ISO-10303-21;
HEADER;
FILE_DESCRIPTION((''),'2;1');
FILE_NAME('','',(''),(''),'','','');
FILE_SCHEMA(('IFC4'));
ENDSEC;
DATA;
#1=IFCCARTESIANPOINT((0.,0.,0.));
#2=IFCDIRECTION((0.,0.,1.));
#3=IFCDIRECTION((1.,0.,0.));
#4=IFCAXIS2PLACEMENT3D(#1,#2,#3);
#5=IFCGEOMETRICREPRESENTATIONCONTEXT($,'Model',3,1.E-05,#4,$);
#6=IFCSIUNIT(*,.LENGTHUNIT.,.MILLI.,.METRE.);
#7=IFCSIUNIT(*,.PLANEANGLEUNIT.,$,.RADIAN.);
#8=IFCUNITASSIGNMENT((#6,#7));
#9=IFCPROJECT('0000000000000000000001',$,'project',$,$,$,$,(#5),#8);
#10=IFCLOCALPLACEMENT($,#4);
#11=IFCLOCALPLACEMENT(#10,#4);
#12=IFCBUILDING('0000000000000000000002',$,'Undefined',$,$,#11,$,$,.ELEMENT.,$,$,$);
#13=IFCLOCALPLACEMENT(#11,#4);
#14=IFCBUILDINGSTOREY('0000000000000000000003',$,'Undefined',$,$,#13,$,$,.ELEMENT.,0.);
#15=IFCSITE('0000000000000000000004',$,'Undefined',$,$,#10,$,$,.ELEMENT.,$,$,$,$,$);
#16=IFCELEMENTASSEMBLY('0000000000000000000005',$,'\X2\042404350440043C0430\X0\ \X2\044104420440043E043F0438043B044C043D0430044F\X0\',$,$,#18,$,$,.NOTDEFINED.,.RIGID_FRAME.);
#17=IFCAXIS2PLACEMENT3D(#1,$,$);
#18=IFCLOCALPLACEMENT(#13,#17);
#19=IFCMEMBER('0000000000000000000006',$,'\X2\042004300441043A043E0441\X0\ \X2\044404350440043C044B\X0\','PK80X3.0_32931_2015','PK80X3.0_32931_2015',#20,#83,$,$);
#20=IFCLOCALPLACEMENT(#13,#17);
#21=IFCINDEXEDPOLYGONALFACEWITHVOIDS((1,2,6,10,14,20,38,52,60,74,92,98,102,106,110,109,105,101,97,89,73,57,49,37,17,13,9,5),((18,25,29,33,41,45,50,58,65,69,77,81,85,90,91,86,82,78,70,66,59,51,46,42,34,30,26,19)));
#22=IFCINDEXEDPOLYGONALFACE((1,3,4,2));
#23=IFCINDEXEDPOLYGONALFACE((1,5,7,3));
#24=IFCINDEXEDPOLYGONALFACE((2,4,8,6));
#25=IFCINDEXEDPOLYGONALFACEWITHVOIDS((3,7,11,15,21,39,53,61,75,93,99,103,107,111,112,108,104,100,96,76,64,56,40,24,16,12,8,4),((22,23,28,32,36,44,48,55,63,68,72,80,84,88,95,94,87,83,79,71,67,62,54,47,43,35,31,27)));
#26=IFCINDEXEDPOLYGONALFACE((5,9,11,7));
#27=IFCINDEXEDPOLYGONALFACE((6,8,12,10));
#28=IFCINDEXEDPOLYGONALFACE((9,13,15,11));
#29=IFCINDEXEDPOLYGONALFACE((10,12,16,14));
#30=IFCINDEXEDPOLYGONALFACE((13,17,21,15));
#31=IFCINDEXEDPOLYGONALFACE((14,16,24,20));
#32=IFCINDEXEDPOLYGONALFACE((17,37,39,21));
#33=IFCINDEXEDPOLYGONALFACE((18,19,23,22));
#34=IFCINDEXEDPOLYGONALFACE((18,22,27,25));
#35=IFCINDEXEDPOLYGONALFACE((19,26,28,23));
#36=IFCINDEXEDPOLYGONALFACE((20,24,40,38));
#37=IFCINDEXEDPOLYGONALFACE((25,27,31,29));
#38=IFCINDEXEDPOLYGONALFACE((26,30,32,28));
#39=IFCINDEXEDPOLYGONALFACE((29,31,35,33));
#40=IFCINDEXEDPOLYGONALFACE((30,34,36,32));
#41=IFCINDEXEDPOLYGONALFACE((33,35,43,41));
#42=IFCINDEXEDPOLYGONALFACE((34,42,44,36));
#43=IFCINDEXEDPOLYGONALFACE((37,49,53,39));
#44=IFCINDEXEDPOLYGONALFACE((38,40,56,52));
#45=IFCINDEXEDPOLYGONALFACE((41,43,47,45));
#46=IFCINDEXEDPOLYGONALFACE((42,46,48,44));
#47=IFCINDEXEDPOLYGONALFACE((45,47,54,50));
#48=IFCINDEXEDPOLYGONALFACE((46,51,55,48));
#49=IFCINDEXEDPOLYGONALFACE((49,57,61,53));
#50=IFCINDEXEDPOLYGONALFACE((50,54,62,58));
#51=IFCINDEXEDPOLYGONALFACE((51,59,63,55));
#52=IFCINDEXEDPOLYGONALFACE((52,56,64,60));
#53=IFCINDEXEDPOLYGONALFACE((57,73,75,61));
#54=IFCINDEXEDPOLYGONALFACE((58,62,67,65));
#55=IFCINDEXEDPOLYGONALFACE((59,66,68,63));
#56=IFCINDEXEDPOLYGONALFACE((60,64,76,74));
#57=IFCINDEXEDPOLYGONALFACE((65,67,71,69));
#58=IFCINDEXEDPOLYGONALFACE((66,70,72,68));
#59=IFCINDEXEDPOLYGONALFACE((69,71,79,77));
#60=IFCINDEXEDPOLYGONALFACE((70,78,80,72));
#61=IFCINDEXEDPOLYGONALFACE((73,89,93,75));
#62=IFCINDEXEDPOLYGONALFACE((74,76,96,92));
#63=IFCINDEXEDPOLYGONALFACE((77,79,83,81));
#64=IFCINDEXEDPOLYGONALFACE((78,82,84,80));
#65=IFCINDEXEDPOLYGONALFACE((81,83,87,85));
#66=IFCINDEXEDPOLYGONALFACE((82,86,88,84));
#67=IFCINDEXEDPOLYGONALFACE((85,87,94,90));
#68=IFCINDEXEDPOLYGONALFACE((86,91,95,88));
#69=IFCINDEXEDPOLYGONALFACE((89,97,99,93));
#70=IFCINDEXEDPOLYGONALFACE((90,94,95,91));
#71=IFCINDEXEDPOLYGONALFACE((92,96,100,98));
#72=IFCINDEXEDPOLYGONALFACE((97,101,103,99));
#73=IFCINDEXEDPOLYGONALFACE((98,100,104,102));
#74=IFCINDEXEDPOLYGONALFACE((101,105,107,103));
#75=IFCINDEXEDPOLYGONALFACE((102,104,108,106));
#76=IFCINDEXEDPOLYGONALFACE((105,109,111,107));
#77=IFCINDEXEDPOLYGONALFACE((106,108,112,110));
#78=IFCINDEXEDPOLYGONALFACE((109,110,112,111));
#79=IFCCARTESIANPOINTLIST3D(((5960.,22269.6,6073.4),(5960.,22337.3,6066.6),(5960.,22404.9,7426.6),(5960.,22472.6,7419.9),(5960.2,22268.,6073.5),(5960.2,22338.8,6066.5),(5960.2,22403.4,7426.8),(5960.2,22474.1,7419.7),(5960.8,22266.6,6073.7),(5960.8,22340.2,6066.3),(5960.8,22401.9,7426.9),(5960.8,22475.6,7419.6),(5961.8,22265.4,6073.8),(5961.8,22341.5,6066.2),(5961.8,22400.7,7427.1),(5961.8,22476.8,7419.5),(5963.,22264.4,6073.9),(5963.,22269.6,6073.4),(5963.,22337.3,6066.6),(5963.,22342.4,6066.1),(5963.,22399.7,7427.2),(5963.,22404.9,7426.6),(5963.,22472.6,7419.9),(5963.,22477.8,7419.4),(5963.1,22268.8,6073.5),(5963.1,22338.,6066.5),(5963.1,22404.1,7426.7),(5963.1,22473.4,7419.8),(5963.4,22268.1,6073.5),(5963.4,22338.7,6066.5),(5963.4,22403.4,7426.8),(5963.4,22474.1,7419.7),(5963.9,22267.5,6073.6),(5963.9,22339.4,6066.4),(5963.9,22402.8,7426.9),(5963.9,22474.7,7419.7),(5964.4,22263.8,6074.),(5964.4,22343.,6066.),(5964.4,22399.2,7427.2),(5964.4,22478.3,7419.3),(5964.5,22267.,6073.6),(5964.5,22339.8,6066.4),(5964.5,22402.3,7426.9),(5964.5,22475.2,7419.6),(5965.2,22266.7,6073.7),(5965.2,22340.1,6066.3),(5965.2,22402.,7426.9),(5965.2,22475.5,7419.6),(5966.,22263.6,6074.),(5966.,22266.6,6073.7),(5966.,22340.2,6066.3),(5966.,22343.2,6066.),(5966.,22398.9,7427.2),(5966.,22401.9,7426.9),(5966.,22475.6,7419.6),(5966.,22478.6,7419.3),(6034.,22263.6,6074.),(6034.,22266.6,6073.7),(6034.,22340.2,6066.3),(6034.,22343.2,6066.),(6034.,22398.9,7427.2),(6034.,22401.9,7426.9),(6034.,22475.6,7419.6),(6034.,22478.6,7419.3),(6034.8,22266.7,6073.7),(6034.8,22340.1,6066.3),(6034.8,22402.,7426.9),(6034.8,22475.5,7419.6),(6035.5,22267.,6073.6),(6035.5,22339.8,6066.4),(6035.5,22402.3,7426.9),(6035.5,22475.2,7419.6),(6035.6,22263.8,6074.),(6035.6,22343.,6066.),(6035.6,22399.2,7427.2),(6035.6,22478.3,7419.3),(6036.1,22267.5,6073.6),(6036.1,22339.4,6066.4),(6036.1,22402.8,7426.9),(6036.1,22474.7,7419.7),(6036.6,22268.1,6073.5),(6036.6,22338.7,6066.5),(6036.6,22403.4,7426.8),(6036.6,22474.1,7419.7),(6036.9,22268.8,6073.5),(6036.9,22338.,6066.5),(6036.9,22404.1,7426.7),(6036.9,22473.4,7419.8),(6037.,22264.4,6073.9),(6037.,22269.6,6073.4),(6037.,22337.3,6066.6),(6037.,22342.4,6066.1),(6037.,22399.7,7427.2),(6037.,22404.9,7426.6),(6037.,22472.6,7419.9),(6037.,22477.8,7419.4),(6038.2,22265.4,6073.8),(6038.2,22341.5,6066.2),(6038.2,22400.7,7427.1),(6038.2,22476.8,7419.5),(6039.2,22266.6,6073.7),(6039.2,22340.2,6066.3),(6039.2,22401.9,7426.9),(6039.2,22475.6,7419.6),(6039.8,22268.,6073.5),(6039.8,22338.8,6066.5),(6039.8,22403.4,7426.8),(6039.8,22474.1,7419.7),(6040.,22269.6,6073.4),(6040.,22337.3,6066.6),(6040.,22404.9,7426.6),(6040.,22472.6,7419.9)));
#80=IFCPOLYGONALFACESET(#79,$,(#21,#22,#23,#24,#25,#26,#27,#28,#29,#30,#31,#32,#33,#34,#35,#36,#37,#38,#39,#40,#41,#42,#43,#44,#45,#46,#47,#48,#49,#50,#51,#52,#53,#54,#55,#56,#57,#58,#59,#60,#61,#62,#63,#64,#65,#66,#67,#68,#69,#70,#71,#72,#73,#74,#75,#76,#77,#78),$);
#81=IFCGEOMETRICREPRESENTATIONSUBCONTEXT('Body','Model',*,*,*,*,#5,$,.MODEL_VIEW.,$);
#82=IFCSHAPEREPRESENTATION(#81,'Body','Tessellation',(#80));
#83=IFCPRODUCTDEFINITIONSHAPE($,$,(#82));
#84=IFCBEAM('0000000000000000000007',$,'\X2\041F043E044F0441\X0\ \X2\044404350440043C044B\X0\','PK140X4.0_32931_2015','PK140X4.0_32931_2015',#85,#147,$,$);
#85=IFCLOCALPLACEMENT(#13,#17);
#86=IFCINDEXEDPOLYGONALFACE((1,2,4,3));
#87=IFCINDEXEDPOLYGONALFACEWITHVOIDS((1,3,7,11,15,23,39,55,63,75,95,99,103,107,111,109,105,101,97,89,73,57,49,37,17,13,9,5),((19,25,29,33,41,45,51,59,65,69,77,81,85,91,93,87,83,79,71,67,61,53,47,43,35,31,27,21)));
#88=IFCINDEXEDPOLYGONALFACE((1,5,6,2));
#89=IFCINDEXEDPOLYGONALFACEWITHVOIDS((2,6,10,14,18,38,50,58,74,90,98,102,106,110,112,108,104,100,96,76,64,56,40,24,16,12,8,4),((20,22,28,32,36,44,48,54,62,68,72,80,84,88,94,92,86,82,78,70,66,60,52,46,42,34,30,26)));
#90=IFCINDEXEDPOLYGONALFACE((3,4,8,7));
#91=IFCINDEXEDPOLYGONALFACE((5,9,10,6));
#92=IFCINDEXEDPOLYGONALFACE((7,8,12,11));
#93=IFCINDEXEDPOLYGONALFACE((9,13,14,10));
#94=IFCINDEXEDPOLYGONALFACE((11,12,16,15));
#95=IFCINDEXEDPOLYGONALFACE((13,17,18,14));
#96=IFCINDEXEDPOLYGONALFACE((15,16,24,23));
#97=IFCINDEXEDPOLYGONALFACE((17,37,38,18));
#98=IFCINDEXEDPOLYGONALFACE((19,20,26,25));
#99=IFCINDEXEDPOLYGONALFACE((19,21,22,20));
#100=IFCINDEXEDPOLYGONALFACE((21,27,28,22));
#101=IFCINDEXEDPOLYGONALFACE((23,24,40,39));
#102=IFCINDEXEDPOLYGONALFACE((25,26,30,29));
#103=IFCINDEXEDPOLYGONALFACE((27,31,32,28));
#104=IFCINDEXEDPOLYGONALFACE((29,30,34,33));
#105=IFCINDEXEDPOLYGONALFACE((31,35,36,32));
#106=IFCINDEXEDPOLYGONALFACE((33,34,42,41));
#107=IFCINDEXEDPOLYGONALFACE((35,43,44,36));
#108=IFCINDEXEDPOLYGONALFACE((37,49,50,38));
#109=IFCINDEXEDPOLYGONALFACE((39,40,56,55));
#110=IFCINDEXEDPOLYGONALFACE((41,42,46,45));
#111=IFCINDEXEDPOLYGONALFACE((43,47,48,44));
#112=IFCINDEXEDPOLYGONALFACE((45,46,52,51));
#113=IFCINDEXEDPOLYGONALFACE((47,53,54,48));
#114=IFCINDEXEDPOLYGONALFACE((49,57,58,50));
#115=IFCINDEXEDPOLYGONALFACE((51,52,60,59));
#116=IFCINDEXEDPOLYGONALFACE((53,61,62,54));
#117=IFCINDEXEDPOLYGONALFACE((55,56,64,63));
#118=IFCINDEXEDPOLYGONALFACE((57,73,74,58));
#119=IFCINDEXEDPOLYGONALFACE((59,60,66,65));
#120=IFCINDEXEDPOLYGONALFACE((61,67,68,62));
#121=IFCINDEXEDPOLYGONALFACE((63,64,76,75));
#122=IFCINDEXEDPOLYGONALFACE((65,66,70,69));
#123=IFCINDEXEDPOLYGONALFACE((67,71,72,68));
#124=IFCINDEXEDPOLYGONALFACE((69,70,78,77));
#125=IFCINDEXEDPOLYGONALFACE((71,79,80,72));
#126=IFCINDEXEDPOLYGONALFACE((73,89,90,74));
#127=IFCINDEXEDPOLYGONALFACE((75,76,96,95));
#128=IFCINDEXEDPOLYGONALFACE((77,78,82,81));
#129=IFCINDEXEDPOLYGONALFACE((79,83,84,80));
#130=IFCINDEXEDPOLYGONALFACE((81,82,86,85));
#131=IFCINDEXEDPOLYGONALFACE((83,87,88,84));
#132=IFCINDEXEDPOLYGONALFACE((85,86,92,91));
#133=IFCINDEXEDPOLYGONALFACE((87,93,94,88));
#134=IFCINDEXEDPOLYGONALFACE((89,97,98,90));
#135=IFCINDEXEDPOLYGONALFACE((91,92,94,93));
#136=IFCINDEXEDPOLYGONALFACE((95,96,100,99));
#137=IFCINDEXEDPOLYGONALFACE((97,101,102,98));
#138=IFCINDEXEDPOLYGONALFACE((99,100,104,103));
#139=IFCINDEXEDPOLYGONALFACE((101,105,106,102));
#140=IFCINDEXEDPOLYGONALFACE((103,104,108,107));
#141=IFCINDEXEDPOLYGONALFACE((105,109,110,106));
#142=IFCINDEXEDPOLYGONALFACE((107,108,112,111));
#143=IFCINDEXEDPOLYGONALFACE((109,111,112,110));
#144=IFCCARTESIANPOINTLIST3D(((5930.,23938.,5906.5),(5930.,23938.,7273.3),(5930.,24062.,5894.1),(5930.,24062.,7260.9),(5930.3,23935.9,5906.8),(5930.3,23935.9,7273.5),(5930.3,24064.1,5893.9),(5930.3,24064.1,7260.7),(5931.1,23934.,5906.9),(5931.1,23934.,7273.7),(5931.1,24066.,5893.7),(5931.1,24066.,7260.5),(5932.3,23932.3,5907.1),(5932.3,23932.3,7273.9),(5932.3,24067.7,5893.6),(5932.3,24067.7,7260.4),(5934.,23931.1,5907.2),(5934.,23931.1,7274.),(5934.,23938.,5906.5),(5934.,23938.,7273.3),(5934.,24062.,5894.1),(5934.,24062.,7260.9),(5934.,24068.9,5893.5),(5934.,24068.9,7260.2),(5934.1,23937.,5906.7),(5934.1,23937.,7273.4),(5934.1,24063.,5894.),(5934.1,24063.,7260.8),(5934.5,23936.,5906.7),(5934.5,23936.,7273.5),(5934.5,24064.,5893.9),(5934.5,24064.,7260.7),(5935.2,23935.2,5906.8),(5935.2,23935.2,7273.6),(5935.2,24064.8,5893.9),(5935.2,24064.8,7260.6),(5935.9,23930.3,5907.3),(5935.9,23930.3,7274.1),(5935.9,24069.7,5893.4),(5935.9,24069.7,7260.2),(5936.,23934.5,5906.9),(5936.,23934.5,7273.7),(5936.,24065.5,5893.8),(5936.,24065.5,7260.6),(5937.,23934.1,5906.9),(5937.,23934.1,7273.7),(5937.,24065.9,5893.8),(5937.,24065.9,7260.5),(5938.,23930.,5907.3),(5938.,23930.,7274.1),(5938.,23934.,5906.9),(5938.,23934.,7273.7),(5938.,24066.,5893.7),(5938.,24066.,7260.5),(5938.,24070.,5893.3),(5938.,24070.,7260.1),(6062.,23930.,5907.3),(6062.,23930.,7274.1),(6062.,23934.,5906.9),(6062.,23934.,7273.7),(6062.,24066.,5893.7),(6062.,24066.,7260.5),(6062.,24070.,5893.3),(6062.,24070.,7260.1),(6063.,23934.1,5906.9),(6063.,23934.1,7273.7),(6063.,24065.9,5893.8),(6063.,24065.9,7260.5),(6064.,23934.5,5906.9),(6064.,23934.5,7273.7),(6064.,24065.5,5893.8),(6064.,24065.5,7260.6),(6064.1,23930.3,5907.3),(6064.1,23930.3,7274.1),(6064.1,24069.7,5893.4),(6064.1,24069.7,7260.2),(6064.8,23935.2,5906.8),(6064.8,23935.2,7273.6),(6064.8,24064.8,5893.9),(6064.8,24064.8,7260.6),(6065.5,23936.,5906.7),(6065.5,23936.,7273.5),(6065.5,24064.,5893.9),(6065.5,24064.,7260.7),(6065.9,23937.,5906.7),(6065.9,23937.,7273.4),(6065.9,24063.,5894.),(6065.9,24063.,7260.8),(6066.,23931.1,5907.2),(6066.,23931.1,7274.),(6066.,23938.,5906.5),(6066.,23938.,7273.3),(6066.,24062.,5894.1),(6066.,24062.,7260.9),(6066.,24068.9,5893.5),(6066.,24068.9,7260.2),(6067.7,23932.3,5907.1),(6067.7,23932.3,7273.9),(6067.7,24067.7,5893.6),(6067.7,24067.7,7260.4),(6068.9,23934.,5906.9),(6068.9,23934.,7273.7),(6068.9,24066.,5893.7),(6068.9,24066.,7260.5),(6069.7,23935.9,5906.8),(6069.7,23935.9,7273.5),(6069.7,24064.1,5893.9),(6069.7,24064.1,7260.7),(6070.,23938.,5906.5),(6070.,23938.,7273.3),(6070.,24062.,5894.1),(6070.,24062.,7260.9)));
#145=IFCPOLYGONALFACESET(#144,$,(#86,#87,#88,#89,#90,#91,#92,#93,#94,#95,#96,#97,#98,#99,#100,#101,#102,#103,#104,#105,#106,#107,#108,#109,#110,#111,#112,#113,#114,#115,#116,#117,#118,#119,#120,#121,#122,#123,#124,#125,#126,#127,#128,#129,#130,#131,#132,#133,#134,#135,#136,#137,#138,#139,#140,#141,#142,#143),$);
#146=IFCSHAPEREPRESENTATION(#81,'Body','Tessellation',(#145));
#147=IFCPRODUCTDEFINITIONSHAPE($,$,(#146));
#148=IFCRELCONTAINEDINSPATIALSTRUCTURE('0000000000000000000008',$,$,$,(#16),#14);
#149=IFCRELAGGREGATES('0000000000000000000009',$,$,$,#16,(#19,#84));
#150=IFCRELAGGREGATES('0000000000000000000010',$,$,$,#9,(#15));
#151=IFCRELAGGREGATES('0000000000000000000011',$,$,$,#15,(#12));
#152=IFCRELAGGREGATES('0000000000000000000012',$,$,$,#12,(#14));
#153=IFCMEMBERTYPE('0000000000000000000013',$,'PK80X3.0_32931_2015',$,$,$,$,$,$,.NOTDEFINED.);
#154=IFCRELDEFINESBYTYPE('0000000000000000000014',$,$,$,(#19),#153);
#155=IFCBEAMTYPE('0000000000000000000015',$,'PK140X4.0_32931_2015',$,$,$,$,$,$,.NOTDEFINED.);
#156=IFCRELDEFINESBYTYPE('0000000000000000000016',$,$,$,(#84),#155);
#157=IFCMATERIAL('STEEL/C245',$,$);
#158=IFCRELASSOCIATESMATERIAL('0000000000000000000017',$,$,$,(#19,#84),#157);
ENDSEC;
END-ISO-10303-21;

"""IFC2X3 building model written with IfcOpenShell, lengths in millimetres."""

from ifc_helpers import new_model, si_unit, frame, origin_with_axes, origin_2d_with_axis, place, context, subcontext, project, spatial, hollow_rectangle, extrude, clip, halfspace, material, type_object, element, aggregate, save


model = new_model("IFC2X3")

# Units and contexts
model_context = context("Model", 3, precision=1e-05, world=origin_with_axes())
body_context = subcontext(model_context, "Body", "Model", "MODEL_VIEW")
ifc_project = project(units=[si_unit("LENGTHUNIT", "METRE", prefix="MILLI"), si_unit("PLANEANGLEUNIT", "RADIAN")], contexts=[model_context])

# Site, building, storey
site_placement = place(None, origin_with_axes())
site = spatial("IfcSite", under=ifc_project, at=site_placement, Name="Undefined", CompositionType="ELEMENT")
building_placement = place(site_placement, origin_with_axes())
building = spatial("IfcBuilding", under=site, at=building_placement, Name="Undefined", CompositionType="ELEMENT")
storey_placement = place(building_placement, origin_with_axes())
storey = spatial("IfcBuildingStorey", under=building, at=storey_placement, Name="Undefined", CompositionType="ELEMENT", Elevation=0.0)

# Shared definitions
ifc_material_1 = material(Name="STEEL/C245")

# Shared definitions
member_type_1 = type_object("IfcMemberType", Name="PK80X3.0_32931_2015", PredefinedType="NOTDEFINED")

# Element assembly, member
assembly_1_placement = place(storey_placement, origin_with_axes())
assembly_1 = element("IfcElementAssembly", 1, at=assembly_1_placement, inside=storey, Name="Ферма стропильная", AssemblyPlace="NOTDEFINED", PredefinedType="RIGID_FRAME")
member_1_placement = place(assembly_1_placement, frame((6000.0, 22438.7, 7423.3), z_axis=(0.0, -0.995037, 0.099504), x_axis=(0.0, -0.099504, -0.995037)))
member_1 = element("IfcMember", 2, at=member_1_placement, type_object=member_type_1, material=ifc_material_1, Name="Раскос фермы", Description="PK80X3.0_32931_2015", ObjectType="PK80X3.0_32931_2015", context=body_context, shape_type="SweptSolid", body=[
    extrude(hollow_rectangle(XDim=80.0, YDim=80.0, WallThickness=3.0, InnerFilletRadius=3.0, OuterFilletRadius=6.0, at=origin_2d_with_axis()), frame((1360.0, 0.0, 0.0), z_axis=(-1.0, 0.0, 0.0), x_axis=(0.0, -1.0, 0.0)), (0.0, 0.0, 1.0), 1360.0),
])

# Beam
beam_type_1 = type_object("IfcBeamType", Name="PK140X4.0_32931_2015", PredefinedType="NOTDEFINED")
beam_1_placement = place(assembly_1_placement, frame((6000.0, 24000.0, 7260.1), z_axis=(1.0, 0.0, 0.0), x_axis=(0.0, 0.0, -1.0)))
beam_1 = element("IfcBeam", 3, at=beam_1_placement, type_object=beam_type_1, material=ifc_material_1, Name="Пояс фермы", Description="PK140X4.0_32931_2015", ObjectType="PK140X4.0_32931_2015", context=body_context, shape_type="Clipping", body=[
    clip(clip(extrude(hollow_rectangle(XDim=140.0, YDim=140.0, WallThickness=4.0, InnerFilletRadius=4.0, OuterFilletRadius=8.0, at=origin_2d_with_axis()), frame((1373.9, 0.0, 0.0), z_axis=(-1.0, 0.0, 0.0), x_axis=(0.0, -1.0, 0.0)), (0.0, 0.0, 1.0), 1395.1), halfspace(frame((1348.5, -112.4, 0.0), z_axis=(0.995037, -0.099504, 0.0), x_axis=(-0.099504, -0.995037, 0.0)), False)), halfspace(frame((-20.7, -136.7, 0.0), z_axis=(0.995037, -0.099504, 0.0), x_axis=(-0.099504, -0.995037, 0.0)), True)),
])
aggregate(assembly_1, [member_1, beam_1])

save(model, "model.ifc")
